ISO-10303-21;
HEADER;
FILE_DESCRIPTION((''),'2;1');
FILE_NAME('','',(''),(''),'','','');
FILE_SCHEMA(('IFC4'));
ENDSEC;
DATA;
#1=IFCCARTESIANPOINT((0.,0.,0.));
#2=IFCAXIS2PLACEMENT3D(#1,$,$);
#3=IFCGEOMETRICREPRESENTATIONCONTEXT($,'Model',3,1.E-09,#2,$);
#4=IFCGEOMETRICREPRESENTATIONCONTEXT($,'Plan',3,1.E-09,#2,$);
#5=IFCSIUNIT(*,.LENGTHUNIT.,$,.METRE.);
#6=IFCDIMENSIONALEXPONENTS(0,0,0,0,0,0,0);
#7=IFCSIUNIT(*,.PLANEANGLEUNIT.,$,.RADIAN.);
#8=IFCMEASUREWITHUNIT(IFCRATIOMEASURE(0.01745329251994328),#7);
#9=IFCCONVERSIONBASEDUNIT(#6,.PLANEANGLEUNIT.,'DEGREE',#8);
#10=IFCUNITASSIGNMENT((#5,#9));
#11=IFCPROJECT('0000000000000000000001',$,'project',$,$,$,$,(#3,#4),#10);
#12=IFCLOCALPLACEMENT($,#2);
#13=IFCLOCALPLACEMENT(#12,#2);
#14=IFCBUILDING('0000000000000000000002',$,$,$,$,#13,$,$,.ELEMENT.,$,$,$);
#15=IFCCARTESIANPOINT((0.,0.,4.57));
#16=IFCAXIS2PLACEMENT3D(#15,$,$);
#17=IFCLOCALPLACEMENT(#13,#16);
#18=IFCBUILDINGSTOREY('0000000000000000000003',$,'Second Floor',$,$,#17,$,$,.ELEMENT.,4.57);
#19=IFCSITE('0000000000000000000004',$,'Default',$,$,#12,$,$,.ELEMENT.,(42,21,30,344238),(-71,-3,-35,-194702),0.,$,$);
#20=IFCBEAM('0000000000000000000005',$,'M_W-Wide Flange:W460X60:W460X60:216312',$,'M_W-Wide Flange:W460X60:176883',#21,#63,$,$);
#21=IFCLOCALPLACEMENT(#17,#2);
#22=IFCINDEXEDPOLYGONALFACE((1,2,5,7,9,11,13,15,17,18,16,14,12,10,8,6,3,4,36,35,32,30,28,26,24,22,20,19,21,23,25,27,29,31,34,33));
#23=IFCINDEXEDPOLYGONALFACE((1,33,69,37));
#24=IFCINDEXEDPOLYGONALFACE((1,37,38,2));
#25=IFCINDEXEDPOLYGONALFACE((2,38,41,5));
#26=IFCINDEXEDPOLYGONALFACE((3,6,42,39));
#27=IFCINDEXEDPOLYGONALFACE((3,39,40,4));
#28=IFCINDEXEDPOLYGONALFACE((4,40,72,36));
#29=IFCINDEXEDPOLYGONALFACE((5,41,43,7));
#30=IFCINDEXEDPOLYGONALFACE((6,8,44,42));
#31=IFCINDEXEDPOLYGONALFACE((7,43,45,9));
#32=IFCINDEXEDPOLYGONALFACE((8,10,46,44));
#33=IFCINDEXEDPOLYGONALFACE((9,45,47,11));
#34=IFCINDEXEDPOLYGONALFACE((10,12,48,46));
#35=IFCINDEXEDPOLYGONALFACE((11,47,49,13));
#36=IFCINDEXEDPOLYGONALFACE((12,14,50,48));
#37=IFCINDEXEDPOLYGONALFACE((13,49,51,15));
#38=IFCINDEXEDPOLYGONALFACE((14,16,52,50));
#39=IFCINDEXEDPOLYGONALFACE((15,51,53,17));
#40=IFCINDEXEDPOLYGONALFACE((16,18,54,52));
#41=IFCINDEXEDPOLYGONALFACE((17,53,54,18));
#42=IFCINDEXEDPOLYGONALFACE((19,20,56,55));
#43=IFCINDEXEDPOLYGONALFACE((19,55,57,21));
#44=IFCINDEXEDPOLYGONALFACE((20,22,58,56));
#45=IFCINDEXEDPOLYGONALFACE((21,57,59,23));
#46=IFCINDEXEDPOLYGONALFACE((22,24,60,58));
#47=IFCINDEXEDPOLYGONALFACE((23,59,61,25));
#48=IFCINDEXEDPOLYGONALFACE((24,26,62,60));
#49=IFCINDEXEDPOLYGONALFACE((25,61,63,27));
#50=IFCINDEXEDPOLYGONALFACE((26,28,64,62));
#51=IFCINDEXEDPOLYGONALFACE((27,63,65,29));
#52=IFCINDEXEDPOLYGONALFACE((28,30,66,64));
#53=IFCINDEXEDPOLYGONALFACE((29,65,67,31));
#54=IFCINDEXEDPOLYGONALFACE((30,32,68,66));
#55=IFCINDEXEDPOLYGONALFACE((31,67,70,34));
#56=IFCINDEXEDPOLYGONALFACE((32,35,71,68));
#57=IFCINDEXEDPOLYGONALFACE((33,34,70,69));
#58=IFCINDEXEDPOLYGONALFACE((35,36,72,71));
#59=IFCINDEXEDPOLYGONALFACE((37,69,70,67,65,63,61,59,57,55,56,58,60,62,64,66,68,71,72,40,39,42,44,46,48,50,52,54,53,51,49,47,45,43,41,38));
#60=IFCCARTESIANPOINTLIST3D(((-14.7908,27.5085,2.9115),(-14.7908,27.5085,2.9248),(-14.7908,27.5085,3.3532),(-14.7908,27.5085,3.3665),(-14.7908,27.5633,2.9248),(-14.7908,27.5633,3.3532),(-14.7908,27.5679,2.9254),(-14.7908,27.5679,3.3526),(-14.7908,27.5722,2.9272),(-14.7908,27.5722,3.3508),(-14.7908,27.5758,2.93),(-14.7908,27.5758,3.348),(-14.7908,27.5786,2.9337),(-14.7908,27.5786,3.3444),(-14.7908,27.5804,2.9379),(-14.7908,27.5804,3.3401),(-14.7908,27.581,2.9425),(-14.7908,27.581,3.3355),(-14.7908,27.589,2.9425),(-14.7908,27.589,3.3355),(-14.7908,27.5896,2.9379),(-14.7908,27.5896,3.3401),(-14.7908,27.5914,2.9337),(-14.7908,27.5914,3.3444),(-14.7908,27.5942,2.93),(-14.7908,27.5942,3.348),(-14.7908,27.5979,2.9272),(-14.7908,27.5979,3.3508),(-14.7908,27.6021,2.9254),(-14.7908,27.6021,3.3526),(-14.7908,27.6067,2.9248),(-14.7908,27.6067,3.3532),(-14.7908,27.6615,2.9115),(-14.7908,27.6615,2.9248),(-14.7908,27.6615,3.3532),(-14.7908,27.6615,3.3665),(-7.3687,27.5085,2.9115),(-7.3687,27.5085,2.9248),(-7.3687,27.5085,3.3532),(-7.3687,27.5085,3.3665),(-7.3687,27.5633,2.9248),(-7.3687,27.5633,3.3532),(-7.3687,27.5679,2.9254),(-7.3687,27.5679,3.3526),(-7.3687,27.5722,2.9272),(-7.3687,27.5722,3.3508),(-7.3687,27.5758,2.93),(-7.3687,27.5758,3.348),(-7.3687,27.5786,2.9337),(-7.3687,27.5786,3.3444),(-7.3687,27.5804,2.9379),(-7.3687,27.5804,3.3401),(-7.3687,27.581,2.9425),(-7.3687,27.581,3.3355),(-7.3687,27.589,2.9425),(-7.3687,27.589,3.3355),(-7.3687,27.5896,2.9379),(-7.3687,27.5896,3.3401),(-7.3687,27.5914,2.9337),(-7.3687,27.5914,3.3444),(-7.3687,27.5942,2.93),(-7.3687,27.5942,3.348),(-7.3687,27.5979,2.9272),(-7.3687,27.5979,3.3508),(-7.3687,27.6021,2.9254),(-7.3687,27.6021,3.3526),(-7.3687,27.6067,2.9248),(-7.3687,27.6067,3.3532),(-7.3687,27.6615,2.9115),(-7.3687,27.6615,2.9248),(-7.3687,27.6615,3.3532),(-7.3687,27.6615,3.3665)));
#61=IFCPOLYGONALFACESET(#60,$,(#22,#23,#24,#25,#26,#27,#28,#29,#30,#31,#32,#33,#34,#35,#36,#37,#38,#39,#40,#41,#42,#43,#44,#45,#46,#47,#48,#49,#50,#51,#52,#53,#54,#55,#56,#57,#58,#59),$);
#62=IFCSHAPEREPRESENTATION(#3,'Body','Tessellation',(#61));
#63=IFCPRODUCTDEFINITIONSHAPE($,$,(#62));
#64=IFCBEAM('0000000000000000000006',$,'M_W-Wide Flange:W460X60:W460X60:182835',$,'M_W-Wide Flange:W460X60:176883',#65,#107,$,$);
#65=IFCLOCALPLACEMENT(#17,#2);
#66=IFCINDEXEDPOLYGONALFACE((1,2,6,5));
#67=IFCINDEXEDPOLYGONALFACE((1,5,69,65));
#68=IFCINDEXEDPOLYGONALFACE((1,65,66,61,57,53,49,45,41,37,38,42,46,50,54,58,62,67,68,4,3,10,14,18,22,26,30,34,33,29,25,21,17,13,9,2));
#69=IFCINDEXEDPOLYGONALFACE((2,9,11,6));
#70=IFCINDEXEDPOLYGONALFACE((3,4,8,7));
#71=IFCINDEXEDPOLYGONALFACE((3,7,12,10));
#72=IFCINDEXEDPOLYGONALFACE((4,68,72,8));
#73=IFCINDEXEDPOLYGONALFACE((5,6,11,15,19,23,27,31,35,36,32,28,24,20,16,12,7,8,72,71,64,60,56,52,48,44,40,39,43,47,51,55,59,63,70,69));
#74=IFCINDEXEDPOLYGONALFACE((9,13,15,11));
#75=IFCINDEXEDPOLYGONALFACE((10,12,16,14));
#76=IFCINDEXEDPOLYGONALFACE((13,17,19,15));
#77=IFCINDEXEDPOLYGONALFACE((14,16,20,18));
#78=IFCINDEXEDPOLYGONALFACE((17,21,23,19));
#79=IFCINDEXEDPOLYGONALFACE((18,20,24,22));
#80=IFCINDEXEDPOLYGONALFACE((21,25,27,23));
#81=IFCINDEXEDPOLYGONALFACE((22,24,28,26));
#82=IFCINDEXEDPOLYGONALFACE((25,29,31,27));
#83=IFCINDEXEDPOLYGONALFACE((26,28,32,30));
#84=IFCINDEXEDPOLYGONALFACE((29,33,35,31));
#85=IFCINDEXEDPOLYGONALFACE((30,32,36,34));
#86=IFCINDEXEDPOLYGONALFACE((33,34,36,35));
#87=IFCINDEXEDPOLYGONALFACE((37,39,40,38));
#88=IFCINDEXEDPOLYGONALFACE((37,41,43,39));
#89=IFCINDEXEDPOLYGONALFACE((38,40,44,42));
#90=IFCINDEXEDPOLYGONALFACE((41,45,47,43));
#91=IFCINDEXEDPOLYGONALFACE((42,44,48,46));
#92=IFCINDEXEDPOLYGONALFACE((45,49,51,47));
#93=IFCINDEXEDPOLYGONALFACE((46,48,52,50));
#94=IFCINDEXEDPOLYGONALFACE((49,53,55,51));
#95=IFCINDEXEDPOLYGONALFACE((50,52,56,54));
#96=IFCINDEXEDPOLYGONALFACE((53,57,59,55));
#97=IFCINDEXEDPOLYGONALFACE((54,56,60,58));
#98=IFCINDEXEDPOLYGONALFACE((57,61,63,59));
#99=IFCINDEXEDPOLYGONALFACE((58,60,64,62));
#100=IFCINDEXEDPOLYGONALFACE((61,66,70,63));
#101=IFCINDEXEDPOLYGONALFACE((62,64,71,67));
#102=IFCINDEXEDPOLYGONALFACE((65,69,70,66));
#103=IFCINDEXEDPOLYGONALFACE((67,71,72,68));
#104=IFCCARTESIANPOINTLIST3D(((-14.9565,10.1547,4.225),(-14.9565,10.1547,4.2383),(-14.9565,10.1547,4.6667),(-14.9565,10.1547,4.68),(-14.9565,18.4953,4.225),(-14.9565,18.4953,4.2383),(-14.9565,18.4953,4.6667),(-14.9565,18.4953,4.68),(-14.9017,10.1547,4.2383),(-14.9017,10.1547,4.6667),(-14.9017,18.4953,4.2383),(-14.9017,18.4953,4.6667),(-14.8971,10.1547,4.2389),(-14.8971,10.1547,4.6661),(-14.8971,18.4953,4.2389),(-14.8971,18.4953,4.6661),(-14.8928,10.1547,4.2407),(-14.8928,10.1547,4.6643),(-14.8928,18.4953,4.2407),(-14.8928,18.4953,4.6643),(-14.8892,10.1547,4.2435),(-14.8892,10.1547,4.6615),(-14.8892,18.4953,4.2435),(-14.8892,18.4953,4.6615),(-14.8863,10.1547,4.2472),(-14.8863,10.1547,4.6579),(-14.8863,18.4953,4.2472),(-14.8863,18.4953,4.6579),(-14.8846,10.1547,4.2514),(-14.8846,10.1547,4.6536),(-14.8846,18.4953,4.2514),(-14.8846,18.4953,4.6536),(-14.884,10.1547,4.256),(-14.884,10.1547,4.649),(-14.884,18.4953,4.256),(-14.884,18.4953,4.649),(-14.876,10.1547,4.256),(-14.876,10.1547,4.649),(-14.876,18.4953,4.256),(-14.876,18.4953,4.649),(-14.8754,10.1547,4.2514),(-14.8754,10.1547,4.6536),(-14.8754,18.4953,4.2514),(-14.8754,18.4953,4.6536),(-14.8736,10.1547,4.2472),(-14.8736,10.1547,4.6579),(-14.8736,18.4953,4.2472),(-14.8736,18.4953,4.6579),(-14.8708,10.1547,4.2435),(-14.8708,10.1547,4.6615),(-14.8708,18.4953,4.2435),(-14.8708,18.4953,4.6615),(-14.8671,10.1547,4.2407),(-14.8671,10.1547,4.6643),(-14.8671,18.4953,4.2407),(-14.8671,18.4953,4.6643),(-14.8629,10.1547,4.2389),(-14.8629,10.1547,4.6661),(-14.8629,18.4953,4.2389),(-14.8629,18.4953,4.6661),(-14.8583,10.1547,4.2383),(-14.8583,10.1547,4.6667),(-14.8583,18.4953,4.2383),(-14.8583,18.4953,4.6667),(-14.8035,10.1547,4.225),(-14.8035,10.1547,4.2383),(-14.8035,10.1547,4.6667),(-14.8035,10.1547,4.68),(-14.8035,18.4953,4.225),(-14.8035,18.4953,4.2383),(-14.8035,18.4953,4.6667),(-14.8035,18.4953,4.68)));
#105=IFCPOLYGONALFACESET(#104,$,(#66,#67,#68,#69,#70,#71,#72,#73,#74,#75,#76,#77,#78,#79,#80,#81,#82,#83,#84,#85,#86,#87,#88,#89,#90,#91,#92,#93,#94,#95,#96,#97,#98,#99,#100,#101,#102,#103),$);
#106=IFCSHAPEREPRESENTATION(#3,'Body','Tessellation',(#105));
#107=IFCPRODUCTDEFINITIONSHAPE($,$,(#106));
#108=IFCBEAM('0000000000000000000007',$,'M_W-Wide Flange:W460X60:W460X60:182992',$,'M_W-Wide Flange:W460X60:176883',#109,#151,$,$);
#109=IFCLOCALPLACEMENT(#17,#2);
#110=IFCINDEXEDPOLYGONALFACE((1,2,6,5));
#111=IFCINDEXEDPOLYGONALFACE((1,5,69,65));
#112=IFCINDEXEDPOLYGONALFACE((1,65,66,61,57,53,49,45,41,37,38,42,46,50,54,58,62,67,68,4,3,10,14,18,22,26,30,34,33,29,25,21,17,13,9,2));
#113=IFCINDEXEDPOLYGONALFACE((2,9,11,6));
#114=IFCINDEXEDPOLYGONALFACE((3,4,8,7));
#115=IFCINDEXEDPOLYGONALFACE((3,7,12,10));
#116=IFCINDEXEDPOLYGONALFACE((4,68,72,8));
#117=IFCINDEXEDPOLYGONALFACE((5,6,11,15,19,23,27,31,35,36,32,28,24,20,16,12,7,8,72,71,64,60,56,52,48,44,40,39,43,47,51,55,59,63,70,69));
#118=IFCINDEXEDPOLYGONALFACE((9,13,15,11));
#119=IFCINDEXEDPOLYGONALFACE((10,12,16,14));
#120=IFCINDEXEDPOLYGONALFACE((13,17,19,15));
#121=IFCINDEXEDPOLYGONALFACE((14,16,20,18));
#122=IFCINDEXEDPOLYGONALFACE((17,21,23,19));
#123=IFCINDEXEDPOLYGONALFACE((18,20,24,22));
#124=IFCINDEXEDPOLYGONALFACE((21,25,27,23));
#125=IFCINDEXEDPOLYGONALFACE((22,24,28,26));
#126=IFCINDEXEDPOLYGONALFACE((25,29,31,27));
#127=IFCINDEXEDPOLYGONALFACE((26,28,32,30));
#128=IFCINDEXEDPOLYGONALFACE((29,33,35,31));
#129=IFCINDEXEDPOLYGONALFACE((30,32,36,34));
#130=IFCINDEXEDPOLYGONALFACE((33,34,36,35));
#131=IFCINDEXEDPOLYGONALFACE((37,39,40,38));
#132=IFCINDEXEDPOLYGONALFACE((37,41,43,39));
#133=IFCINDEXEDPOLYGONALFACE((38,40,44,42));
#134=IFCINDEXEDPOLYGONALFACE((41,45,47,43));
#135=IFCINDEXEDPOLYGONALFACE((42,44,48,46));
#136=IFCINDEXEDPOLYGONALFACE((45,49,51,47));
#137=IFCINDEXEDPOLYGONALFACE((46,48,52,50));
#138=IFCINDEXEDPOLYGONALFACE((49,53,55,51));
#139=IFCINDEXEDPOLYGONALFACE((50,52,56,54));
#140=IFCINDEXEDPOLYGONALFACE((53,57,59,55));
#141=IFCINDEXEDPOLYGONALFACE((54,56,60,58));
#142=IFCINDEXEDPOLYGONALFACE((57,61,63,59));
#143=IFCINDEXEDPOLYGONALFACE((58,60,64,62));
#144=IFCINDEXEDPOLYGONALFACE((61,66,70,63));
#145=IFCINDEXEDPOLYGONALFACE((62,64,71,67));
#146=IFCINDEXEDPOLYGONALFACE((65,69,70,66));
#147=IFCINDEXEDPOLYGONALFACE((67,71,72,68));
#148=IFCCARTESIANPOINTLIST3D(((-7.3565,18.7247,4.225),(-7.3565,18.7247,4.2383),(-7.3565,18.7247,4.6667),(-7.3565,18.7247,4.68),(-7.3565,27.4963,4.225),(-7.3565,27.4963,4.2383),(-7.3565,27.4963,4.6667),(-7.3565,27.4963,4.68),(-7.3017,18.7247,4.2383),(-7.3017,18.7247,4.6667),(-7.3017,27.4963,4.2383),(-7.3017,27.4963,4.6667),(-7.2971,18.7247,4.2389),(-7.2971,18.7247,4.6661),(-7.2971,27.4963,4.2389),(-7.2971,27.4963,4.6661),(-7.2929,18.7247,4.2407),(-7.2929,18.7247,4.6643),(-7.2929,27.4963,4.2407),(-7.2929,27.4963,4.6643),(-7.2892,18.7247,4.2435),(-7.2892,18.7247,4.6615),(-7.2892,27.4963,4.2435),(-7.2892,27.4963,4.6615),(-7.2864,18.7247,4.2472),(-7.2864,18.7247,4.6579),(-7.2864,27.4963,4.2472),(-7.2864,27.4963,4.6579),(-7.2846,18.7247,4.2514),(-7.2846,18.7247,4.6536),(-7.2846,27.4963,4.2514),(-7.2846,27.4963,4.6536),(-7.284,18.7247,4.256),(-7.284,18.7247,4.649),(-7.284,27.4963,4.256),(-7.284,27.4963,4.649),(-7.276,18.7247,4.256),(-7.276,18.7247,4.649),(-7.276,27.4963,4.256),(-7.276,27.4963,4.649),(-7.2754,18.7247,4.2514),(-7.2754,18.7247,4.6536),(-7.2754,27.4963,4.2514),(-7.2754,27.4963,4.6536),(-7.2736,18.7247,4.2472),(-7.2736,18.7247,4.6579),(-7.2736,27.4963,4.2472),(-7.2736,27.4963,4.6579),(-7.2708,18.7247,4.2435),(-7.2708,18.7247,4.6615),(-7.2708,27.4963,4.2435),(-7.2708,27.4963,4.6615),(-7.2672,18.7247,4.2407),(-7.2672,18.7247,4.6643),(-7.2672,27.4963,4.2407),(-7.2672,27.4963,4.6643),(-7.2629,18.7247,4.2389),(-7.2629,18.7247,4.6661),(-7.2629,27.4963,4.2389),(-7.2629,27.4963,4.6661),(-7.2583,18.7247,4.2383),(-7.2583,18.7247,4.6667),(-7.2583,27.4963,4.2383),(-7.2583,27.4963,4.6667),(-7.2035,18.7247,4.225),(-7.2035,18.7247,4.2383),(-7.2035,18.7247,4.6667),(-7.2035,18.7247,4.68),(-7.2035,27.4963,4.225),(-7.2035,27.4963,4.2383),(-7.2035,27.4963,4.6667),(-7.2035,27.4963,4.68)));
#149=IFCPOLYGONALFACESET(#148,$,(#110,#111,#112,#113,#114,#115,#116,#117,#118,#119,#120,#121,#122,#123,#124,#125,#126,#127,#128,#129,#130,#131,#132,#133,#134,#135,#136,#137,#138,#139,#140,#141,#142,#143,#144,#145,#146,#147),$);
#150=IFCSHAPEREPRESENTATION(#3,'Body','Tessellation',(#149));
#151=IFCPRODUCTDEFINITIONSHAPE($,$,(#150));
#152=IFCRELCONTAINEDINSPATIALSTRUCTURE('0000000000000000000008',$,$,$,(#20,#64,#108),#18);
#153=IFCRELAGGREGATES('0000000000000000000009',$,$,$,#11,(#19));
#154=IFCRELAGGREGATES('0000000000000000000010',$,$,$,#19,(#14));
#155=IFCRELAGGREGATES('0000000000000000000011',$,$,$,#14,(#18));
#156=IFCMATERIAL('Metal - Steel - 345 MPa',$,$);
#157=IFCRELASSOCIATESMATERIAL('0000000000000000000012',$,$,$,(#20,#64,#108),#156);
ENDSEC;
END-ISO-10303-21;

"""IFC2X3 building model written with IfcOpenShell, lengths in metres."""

from ifc_helpers import new_model, entity, si_unit, converted_unit, frame, frame_2d, origin, place, context, project, spatial, polyline, circle_curve, parameter, trimmed, segment, composite_curve, outline, extrude, material, element, save


model = new_model("IFC2X3")

# Units and contexts
model_context = context("Model", 3, precision=1e-09, world=origin())
plan_context = context("Plan", 3, precision=1e-09, world=origin())
ifc_project = project(units=[si_unit("LENGTHUNIT", "METRE"), converted_unit("PLANEANGLEUNIT", "DEGREE", entity("IfcRatioMeasure", 0.01745329251994328), si_unit("PLANEANGLEUNIT", "RADIAN"), dimensions=[0, 0, 0, 0, 0, 0, 0])], contexts=[model_context, plan_context])

# Site, building, storey
site_placement = place(None, origin())
site = spatial("IfcSite", under=ifc_project, at=site_placement, Name="Default", CompositionType="ELEMENT", RefLatitude=(42, 21, 30, 344238), RefLongitude=(-71, -3, -35, -194702), RefElevation=0.0)
building_placement = place(site_placement, origin())
building = spatial("IfcBuilding", under=site, at=building_placement, CompositionType="ELEMENT")
storey_placement = place(building_placement, frame((0.0, 0.0, 4.57)))
storey = spatial("IfcBuildingStorey", under=building, at=storey_placement, Name="Second Floor", CompositionType="ELEMENT", Elevation=4.57)

# Shared definitions
ifc_material = material(Name="Metal - Steel - 345 MPa")

# Beams
beam_1_placement = place(storey_placement, frame((-7.2774, 27.585, 3.3665), z_axis=(0.0, 0.0, 1.0), x_axis=(0.0, -1.0, 0.0)))
element("IfcBeam", 1, at=beam_1_placement, inside=storey, material=ifc_material, Name="M_W-Wide Flange:W460X60:W460X60:216312", ObjectType="M_W-Wide Flange:W460X60:176883", context=model_context, shape_type="SweptSolid", body=[
    extrude(outline(composite_curve([segment(polyline([(0.2142, -0.0765), (0.2275, -0.0765)]), True, "CONTINUOUS"), segment(polyline([(0.2275, -0.0765), (0.2275, 0.0765)]), True, "CONTINUOUS"), segment(polyline([(0.2275, 0.0765), (0.2142, 0.0765)]), True, "CONTINUOUS"), segment(polyline([(0.2142, 0.0765), (0.2142, 0.0217)]), True, "CONTINUOUS"), segment(trimmed(circle_curve(frame_2d((0.1965, 0.0217), x_axis=(0.0, 1.0)), 0.0177), [parameter(180.0)], [parameter(270.0)], True, "PARAMETER"), False, "CONTINUOUS"), segment(polyline([(0.1965, 0.004), (-0.1965, 0.004)]), True, "CONTINUOUS"), segment(trimmed(circle_curve(frame_2d((-0.1965, 0.0217), x_axis=(0.0, 1.0)), 0.0177), [parameter(90.0)], [parameter(180.0)], True, "PARAMETER"), False, "CONTINUOUS"), segment(polyline([(-0.2142, 0.0217), (-0.2142, 0.0765)]), True, "CONTINUOUS"), segment(polyline([(-0.2142, 0.0765), (-0.2275, 0.0765)]), True, "CONTINUOUS"), segment(polyline([(-0.2275, 0.0765), (-0.2275, -0.0765)]), True, "CONTINUOUS"), segment(polyline([(-0.2275, -0.0765), (-0.2142, -0.0765)]), True, "CONTINUOUS"), segment(polyline([(-0.2142, -0.0765), (-0.2142, -0.0217)]), True, "CONTINUOUS"), segment(trimmed(circle_curve(frame_2d((-0.1965, -0.0217), x_axis=(0.0, 1.0)), 0.0177), [parameter(360.0)], [parameter(90.0)], True, "PARAMETER"), False, "CONTINUOUS"), segment(polyline([(-0.1965, -0.004), (0.1965, -0.004)]), True, "CONTINUOUS"), segment(trimmed(circle_curve(frame_2d((0.1965, -0.0217), x_axis=(0.0, 1.0)), 0.0177), [parameter(270.0)], [parameter(0.0)], True, "PARAMETER"), False, "CONTINUOUS"), segment(polyline([(0.2142, -0.0217), (0.2142, -0.0765)]), True, "CONTINUOUS")], self_intersect=False)), frame((0.0, -7.5134, -0.2275), z_axis=(0.0, 1.0, 0.0), x_axis=(0.0, 0.0, -1.0)), (0.0, 0.0, 1.0), 7.4221),
])
beam_2_placement = place(storey_placement, frame((-14.88, 18.6078, 4.68), z_axis=(0.0, 0.0, 1.0), x_axis=(-1.0, 0.0, 0.0)))
element("IfcBeam", 2, at=beam_2_placement, inside=storey, material=ifc_material, Name="M_W-Wide Flange:W460X60:W460X60:182835", ObjectType="M_W-Wide Flange:W460X60:176883", context=model_context, shape_type="SweptSolid", body=[
    extrude(outline(composite_curve([segment(polyline([(0.2142, -0.0765), (0.2275, -0.0765)]), True, "CONTINUOUS"), segment(polyline([(0.2275, -0.0765), (0.2275, 0.0765)]), True, "CONTINUOUS"), segment(polyline([(0.2275, 0.0765), (0.2142, 0.0765)]), True, "CONTINUOUS"), segment(polyline([(0.2142, 0.0765), (0.2142, 0.0217)]), True, "CONTINUOUS"), segment(trimmed(circle_curve(frame_2d((0.1965, 0.0217), x_axis=(1.0, 0.0)), 0.0177), [parameter(270.0)], [parameter(360.0)], True, "PARAMETER"), False, "CONTINUOUS"), segment(polyline([(0.1965, 0.004), (-0.1965, 0.004)]), True, "CONTINUOUS"), segment(trimmed(circle_curve(frame_2d((-0.1965, 0.0217), x_axis=(0.0, -1.0)), 0.0177), [parameter(270.0)], [parameter(360.0)], True, "PARAMETER"), False, "CONTINUOUS"), segment(polyline([(-0.2142, 0.0217), (-0.2142, 0.0765)]), True, "CONTINUOUS"), segment(polyline([(-0.2142, 0.0765), (-0.2275, 0.0765)]), True, "CONTINUOUS"), segment(polyline([(-0.2275, 0.0765), (-0.2275, -0.0765)]), True, "CONTINUOUS"), segment(polyline([(-0.2275, -0.0765), (-0.2142, -0.0765)]), True, "CONTINUOUS"), segment(polyline([(-0.2142, -0.0765), (-0.2142, -0.0217)]), True, "CONTINUOUS"), segment(trimmed(circle_curve(frame_2d((-0.1965, -0.0217), x_axis=(-1.0, 0.0)), 0.0177), [parameter(270.0)], [parameter(360.0)], True, "PARAMETER"), False, "CONTINUOUS"), segment(polyline([(-0.1965, -0.004), (0.1965, -0.004)]), True, "CONTINUOUS"), segment(trimmed(circle_curve(frame_2d((0.1965, -0.0217), x_axis=(0.0, 1.0)), 0.0177), [parameter(270.0)], [parameter(0.0)], True, "PARAMETER"), False, "CONTINUOUS"), segment(polyline([(0.2142, -0.0217), (0.2142, -0.0765)]), True, "CONTINUOUS")], self_intersect=False)), frame((0.0, 8.4531, -0.2275), z_axis=(0.0, -1.0, 0.0), x_axis=(0.0, 0.0, -1.0)), (0.0, 0.0, 1.0), 8.3406),
])
beam_3_placement = place(storey_placement, frame((-7.28, 18.6119, 4.68)))
element("IfcBeam", 3, at=beam_3_placement, inside=storey, material=ifc_material, Name="M_W-Wide Flange:W460X60:W460X60:182992", ObjectType="M_W-Wide Flange:W460X60:176883", context=model_context, shape_type="SweptSolid", body=[
    extrude(outline(composite_curve([segment(polyline([(-0.0765, -0.2142), (-0.0765, -0.2275)]), True, "CONTINUOUS"), segment(polyline([(-0.0765, -0.2275), (0.0765, -0.2275)]), True, "CONTINUOUS"), segment(polyline([(0.0765, -0.2275), (0.0765, -0.2142)]), True, "CONTINUOUS"), segment(polyline([(0.0765, -0.2142), (0.0217, -0.2142)]), True, "CONTINUOUS"), segment(trimmed(circle_curve(frame_2d((0.0217, -0.1965), x_axis=(1.0, 0.0)), 0.0177), [parameter(180.0)], [parameter(270.0)], True, "PARAMETER"), False, "CONTINUOUS"), segment(polyline([(0.004, -0.1965), (0.004, 0.1965)]), True, "CONTINUOUS"), segment(trimmed(circle_curve(frame_2d((0.0217, 0.1965), x_axis=(1.0, 0.0)), 0.0177), [parameter(90.0)], [parameter(180.0)], True, "PARAMETER"), False, "CONTINUOUS"), segment(polyline([(0.0217, 0.2142), (0.0765, 0.2142)]), True, "CONTINUOUS"), segment(polyline([(0.0765, 0.2142), (0.0765, 0.2275)]), True, "CONTINUOUS"), segment(polyline([(0.0765, 0.2275), (-0.0765, 0.2275)]), True, "CONTINUOUS"), segment(polyline([(-0.0765, 0.2275), (-0.0765, 0.2142)]), True, "CONTINUOUS"), segment(polyline([(-0.0765, 0.2142), (-0.0217, 0.2142)]), True, "CONTINUOUS"), segment(trimmed(circle_curve(frame_2d((-0.0217, 0.1965), x_axis=(1.0, 0.0)), 0.0177), [parameter(360.0)], [parameter(90.0)], True, "PARAMETER"), False, "CONTINUOUS"), segment(polyline([(-0.004, 0.1965), (-0.004, -0.1965)]), True, "CONTINUOUS"), segment(trimmed(circle_curve(frame_2d((-0.0217, -0.1965), x_axis=(1.0, 0.0)), 0.0177), [parameter(270.0)], [parameter(0.0)], True, "PARAMETER"), False, "CONTINUOUS"), segment(polyline([(-0.0217, -0.2142), (-0.0765, -0.2142)]), True, "CONTINUOUS")], self_intersect=False)), frame((0.0, 0.1128, -0.2275), z_axis=(0.0, -1.0, 0.0), x_axis=(1.0, 0.0, 0.0)), (0.0, 0.0, -1.0), 8.7716),
])

save(model, "model.ifc")
